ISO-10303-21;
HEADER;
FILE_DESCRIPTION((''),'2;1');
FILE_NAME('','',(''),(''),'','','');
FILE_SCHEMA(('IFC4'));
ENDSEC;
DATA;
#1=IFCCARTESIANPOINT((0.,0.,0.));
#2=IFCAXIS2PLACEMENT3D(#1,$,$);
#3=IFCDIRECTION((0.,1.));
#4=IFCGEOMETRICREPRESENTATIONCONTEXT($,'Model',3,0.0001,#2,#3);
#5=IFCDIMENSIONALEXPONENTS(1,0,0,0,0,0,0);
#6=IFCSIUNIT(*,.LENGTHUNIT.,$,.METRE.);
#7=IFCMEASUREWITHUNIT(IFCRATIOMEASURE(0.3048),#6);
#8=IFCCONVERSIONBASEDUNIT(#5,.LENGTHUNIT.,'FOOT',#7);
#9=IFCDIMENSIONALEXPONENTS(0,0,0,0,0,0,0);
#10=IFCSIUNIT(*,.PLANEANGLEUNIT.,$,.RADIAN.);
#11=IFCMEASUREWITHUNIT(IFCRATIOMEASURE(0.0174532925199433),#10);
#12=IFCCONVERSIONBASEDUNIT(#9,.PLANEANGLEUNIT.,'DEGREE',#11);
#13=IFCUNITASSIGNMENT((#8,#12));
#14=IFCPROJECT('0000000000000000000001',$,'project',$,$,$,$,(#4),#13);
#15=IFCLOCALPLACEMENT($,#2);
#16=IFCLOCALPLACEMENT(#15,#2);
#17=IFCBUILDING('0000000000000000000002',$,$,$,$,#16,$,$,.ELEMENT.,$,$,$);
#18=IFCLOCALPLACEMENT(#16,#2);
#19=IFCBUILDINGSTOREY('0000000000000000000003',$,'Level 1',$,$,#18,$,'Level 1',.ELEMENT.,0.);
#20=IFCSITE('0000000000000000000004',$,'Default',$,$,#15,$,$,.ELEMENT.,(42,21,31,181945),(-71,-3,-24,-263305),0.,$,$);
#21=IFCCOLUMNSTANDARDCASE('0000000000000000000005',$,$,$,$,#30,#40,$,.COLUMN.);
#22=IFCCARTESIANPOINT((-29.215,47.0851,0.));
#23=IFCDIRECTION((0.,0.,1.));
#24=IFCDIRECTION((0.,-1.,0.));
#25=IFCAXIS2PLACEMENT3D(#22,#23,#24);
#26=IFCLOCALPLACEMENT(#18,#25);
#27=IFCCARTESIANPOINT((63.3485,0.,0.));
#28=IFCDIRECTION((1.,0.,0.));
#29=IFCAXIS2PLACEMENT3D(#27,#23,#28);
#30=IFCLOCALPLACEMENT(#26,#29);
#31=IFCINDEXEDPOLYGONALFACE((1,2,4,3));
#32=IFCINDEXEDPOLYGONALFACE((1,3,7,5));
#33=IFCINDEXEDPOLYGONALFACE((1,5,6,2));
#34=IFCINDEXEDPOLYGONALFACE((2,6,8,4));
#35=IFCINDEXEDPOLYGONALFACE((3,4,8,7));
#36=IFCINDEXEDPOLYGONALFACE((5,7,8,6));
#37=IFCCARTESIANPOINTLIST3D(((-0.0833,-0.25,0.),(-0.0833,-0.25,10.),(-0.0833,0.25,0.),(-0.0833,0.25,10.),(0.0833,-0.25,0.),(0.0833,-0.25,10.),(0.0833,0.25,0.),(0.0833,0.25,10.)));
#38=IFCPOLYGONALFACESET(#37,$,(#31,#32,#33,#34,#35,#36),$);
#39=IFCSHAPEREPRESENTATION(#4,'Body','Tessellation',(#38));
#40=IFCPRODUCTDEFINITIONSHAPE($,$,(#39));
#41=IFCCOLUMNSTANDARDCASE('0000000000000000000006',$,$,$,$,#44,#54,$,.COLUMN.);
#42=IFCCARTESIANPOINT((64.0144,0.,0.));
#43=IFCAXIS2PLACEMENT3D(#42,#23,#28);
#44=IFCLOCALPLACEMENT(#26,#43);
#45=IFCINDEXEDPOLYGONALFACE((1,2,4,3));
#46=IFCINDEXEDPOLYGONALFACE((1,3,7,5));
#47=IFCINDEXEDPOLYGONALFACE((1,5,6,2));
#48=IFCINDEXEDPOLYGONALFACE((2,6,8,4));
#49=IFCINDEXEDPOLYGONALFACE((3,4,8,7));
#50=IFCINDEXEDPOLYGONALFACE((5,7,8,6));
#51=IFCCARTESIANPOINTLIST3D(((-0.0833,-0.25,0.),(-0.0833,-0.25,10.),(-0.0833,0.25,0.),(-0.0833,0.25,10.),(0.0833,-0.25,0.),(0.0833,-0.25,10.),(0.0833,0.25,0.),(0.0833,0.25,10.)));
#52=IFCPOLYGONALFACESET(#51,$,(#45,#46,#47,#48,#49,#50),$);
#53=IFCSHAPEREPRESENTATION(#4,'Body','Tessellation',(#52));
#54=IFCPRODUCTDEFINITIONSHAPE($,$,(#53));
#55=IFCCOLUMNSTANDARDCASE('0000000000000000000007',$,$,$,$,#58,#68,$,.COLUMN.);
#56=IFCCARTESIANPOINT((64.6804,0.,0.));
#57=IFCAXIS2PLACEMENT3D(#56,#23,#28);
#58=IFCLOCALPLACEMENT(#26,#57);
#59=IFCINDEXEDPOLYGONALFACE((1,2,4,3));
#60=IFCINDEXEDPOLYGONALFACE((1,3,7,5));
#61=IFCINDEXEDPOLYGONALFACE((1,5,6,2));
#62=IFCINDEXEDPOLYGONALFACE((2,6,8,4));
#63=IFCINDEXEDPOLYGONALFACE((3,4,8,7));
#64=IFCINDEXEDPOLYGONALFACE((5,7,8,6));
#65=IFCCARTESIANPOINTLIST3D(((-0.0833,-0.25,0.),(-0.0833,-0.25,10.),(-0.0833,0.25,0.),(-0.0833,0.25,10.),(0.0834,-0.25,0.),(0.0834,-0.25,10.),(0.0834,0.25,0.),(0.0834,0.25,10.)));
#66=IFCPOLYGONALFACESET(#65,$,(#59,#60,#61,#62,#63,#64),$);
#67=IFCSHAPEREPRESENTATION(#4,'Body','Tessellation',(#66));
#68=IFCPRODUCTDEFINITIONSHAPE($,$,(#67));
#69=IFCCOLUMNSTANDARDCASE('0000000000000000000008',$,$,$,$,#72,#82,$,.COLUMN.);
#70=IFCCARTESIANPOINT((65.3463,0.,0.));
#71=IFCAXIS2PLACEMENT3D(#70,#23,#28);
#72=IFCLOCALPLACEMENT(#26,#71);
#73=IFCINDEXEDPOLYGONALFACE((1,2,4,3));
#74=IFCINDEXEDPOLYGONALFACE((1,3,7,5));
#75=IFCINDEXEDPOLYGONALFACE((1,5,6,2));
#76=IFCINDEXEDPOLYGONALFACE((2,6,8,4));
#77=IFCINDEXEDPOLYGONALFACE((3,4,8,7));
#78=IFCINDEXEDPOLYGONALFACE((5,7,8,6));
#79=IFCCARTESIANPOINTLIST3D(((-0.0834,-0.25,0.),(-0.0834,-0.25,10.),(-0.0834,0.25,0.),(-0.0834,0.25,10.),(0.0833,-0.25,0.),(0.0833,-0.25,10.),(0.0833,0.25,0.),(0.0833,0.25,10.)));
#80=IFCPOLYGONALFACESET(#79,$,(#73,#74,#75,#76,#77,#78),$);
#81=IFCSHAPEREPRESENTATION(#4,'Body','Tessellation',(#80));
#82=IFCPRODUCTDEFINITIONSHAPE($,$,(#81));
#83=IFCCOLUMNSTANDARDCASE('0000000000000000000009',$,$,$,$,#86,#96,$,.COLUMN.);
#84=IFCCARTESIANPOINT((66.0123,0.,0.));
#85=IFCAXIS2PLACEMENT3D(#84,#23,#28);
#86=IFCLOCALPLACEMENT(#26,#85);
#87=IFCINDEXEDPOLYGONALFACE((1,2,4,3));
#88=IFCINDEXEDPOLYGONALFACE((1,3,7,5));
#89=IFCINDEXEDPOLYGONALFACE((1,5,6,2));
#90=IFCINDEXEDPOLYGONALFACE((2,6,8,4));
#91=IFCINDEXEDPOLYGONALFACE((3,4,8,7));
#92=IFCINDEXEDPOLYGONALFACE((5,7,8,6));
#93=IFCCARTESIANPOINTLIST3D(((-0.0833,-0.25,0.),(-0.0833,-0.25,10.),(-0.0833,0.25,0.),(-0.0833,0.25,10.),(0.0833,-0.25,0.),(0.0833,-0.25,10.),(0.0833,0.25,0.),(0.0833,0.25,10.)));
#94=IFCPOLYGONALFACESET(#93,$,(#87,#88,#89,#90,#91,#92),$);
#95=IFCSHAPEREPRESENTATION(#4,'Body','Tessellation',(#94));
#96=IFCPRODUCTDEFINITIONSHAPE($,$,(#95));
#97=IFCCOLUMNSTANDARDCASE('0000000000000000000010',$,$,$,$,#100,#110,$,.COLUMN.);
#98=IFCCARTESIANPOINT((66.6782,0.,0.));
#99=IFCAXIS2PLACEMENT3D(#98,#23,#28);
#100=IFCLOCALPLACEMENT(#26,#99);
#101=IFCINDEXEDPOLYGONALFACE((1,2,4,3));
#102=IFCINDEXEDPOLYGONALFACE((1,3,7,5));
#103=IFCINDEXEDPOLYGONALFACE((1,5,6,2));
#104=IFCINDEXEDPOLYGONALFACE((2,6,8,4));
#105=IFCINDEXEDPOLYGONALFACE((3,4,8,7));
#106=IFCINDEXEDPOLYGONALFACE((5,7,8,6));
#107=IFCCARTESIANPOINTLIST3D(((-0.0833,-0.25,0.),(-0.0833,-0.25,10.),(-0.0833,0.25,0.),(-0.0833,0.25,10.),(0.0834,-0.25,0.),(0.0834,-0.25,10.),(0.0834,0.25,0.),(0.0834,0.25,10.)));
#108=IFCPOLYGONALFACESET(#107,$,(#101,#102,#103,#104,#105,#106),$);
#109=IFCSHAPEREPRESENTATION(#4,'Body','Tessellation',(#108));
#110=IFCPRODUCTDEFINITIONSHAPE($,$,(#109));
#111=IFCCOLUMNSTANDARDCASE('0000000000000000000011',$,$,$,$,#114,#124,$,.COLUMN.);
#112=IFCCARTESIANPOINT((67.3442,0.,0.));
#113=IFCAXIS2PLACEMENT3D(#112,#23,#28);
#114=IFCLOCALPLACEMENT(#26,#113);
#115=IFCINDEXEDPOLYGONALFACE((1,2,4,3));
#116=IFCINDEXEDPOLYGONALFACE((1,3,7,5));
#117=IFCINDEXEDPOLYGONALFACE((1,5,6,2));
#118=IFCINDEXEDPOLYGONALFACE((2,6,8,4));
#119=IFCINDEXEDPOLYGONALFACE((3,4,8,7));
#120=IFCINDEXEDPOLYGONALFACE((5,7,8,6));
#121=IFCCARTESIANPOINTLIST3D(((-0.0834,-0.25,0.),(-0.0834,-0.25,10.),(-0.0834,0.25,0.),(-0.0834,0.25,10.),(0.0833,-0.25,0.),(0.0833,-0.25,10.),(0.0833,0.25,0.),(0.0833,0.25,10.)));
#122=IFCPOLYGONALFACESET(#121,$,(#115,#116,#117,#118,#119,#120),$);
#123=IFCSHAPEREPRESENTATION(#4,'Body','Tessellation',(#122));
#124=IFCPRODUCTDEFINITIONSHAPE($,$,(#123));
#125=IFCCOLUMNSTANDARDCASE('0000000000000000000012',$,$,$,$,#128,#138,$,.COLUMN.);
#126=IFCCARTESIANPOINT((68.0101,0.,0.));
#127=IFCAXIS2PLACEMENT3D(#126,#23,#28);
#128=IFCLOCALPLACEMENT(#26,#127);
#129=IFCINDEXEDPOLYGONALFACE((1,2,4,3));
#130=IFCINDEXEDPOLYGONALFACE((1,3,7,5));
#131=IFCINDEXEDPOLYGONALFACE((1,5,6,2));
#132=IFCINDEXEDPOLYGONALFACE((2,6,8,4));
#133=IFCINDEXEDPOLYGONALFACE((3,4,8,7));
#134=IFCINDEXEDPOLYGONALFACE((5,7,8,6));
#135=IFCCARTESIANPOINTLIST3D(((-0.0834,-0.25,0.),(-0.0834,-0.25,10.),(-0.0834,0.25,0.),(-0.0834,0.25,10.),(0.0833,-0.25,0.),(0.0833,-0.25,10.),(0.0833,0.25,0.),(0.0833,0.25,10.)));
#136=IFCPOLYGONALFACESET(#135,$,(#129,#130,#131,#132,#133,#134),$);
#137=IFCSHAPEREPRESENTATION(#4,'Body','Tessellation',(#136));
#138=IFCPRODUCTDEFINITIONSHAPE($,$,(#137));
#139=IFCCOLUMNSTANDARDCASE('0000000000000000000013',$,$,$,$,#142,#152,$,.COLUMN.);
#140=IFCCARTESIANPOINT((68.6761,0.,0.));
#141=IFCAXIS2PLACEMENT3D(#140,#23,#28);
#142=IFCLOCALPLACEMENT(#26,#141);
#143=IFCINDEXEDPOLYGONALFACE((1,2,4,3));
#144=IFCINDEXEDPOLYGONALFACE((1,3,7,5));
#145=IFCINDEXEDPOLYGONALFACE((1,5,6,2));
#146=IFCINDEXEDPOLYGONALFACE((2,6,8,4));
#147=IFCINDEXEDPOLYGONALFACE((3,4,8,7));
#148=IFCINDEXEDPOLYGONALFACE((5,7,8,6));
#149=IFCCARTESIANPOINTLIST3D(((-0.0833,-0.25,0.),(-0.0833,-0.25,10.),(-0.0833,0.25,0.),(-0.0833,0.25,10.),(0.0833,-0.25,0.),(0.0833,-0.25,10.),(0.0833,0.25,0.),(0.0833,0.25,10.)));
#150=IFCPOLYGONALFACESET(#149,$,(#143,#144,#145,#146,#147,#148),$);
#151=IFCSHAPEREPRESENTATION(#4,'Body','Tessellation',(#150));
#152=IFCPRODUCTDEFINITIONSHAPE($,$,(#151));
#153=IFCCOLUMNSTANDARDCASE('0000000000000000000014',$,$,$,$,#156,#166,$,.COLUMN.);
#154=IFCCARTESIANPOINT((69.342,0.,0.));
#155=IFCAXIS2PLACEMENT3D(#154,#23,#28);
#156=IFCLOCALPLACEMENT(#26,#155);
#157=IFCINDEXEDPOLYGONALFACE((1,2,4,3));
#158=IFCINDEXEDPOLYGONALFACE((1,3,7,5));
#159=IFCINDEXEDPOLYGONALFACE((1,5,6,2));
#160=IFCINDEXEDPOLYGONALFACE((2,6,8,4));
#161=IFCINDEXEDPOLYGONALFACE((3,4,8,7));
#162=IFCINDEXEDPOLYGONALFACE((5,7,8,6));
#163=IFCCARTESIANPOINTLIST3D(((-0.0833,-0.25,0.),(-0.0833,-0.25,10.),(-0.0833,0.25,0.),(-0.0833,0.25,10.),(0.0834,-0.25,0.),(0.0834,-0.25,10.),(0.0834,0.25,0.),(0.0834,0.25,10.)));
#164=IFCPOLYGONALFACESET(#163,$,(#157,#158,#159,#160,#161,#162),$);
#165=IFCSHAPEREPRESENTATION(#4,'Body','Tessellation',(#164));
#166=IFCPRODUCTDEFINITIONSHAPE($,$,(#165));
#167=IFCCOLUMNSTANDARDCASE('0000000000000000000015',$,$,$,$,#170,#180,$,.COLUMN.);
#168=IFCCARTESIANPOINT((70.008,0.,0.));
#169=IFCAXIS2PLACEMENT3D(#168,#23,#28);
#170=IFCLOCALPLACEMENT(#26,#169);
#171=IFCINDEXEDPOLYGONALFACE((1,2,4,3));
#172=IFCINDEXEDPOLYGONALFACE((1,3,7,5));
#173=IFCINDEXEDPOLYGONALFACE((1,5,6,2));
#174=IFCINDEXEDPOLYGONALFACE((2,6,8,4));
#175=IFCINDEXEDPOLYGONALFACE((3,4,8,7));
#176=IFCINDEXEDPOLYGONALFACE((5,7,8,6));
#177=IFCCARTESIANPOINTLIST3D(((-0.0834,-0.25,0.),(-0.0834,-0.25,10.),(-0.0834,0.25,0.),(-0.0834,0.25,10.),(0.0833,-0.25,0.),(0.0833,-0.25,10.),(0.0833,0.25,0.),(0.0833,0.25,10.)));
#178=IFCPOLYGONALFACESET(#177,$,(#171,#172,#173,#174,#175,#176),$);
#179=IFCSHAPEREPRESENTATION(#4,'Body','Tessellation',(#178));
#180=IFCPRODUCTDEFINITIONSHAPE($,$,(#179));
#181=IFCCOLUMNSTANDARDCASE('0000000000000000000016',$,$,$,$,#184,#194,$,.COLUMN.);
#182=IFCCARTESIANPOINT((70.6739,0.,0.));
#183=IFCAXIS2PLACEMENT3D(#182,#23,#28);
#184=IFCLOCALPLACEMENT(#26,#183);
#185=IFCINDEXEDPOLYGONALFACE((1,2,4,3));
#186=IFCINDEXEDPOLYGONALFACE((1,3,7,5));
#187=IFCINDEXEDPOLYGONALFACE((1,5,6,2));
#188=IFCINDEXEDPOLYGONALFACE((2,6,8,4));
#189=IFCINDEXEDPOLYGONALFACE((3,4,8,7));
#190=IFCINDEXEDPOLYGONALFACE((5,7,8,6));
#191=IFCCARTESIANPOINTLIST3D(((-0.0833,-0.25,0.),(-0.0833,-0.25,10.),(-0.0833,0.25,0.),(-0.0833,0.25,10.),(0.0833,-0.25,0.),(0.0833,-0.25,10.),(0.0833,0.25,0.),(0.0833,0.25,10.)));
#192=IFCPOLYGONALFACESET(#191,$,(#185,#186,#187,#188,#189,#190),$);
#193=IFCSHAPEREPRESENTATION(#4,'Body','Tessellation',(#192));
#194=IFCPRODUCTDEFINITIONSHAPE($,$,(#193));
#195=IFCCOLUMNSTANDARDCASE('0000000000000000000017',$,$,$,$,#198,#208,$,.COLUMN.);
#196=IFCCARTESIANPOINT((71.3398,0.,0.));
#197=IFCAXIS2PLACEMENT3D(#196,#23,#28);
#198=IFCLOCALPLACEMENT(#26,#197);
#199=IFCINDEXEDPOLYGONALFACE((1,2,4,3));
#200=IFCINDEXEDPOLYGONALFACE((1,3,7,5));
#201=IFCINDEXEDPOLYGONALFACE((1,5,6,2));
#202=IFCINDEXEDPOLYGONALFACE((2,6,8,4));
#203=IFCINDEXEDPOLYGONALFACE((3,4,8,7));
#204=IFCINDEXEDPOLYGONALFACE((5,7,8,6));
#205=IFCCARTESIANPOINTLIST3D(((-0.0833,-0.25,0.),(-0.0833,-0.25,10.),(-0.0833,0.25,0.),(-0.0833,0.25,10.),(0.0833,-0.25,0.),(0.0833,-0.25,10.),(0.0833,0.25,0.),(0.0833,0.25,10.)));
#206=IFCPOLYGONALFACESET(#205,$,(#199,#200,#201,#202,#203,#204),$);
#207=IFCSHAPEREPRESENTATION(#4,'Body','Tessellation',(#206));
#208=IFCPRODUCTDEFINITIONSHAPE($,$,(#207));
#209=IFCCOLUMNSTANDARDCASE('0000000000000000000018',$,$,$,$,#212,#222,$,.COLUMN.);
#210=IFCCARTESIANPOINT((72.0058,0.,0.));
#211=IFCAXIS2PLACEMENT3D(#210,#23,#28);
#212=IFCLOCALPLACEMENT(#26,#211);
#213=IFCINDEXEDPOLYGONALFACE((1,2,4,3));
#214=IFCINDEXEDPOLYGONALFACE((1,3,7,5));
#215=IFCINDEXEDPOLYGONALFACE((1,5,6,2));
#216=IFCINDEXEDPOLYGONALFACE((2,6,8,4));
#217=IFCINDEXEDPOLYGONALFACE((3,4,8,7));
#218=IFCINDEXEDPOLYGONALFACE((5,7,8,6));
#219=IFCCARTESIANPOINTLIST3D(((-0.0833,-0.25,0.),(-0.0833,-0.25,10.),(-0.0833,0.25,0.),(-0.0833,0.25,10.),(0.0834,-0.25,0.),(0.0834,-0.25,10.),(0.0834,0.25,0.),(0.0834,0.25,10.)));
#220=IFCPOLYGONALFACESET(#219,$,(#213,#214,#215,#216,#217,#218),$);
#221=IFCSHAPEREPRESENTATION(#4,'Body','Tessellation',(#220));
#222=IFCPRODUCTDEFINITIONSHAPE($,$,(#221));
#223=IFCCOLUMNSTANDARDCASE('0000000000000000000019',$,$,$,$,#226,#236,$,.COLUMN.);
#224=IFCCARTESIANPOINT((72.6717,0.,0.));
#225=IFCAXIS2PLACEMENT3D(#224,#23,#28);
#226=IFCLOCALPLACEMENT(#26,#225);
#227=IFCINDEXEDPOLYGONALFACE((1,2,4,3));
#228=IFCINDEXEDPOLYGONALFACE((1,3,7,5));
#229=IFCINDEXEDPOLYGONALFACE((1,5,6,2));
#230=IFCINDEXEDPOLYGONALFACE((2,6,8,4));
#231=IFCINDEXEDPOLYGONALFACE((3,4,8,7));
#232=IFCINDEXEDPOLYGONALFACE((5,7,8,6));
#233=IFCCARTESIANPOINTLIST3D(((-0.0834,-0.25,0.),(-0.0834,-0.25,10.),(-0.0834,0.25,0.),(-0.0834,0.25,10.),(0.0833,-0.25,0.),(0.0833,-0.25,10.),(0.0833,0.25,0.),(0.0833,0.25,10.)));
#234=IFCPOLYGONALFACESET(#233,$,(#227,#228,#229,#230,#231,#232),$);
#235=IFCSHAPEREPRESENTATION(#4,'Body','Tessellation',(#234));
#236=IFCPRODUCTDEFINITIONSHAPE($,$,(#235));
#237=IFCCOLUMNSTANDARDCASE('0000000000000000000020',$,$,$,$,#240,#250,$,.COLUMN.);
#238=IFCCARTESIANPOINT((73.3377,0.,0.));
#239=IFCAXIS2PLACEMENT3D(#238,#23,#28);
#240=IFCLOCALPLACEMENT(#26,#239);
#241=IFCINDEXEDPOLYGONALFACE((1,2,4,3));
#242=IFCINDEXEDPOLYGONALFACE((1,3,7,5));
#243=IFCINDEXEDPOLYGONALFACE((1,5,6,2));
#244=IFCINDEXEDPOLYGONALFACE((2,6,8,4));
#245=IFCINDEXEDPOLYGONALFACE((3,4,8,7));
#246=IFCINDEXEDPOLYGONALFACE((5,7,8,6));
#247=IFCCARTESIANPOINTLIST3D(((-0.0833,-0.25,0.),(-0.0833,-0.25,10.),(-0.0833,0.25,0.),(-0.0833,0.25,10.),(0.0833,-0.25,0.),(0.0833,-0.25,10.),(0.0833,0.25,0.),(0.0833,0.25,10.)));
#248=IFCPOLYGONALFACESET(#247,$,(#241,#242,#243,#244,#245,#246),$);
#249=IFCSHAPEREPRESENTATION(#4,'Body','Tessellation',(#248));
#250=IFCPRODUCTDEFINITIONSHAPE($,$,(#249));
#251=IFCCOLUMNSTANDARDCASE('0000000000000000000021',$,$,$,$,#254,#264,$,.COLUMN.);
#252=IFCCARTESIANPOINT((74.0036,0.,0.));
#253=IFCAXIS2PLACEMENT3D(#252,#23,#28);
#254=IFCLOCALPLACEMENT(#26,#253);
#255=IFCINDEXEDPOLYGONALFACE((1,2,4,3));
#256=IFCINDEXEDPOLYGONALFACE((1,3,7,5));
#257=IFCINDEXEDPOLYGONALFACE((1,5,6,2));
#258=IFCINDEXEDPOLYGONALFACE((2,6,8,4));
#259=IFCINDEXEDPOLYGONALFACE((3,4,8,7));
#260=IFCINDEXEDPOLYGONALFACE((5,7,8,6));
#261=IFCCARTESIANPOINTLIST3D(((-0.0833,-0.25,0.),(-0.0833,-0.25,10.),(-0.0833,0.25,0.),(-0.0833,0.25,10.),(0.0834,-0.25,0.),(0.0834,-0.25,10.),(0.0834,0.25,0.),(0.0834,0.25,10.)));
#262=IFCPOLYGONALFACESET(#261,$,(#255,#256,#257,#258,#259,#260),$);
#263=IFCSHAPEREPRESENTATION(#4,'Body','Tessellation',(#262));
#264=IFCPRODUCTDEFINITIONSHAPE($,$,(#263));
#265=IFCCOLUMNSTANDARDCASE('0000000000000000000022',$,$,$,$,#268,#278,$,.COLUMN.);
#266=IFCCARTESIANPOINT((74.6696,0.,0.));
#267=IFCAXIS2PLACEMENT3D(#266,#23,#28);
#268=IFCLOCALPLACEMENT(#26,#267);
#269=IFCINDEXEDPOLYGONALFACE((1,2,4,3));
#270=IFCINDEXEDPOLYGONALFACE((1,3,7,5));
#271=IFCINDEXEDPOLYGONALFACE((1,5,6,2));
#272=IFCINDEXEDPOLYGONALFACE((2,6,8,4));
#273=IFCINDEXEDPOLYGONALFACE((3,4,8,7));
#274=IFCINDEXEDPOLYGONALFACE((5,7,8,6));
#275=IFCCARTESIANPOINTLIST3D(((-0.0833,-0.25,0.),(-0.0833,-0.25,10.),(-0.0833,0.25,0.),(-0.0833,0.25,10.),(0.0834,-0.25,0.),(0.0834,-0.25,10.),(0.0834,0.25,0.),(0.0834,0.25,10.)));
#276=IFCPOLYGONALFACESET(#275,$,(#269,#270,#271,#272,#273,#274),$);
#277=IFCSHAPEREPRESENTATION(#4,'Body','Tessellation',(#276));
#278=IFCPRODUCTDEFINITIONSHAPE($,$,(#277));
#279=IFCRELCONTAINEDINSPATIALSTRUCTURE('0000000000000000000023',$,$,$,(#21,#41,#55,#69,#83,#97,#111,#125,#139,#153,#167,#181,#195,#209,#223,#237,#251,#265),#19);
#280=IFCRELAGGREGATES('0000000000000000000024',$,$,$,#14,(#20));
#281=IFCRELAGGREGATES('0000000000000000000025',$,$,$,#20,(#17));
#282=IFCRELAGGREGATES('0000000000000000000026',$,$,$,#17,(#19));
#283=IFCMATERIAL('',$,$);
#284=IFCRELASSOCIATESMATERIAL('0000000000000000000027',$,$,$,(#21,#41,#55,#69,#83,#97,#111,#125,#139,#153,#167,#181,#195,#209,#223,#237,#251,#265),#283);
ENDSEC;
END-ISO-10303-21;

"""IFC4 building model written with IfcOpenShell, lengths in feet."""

from ifc_helpers import new_model, entity, si_unit, converted_unit, direction, frame, origin, place, context, project, spatial, rectangle, extrude, material, element, save


model = new_model("IFC4")

# Units and contexts
model_context = context("Model", 3, precision=0.0001, world=origin(), true_north=direction((0.0, 1.0)))
ifc_project = project(units=[converted_unit("LENGTHUNIT", "FOOT", entity("IfcRatioMeasure", 0.3048), si_unit("LENGTHUNIT", "METRE"), dimensions=[1, 0, 0, 0, 0, 0, 0]), converted_unit("PLANEANGLEUNIT", "DEGREE", entity("IfcRatioMeasure", 0.0174532925199433), si_unit("PLANEANGLEUNIT", "RADIAN"), dimensions=[0, 0, 0, 0, 0, 0, 0])], contexts=[model_context])

# Site, building, storey
site_placement = place(None, origin())
site = spatial("IfcSite", under=ifc_project, at=site_placement, Name="Default", CompositionType="ELEMENT", RefLatitude=(42, 21, 31, 181945), RefLongitude=(-71, -3, -24, -263305), RefElevation=0.0)
building_placement = place(site_placement, origin())
building = spatial("IfcBuilding", under=site, at=building_placement, CompositionType="ELEMENT")
storey_placement = place(building_placement, origin())
storey = spatial("IfcBuildingStorey", under=building, at=storey_placement, Name="Level 1", LongName="Level 1", CompositionType="ELEMENT", Elevation=0.0)

# Columns
ifc_material_1 = material(Name="")
placement = place(storey_placement, frame((-29.215, 47.0851, 0.0), z_axis=(0.0, 0.0, 1.0), x_axis=(0.0, -1.0, 0.0)))
for number, where, z_axis, x_axis in (
    (1, (63.3485, 0.0, 0.0), (0.0, 0.0, 1.0), (1.0, 0.0, 0.0)),
    (2, (64.0144, 0.0, 0.0), (0.0, 0.0, 1.0), (1.0, 0.0, 0.0)),
    (3, (64.6804, 0.0, 0.0), (0.0, 0.0, 1.0), (1.0, 0.0, 0.0)),
    (4, (65.3463, 0.0, 0.0), (0.0, 0.0, 1.0), (1.0, 0.0, 0.0)),
    (5, (66.0123, 0.0, 0.0), (0.0, 0.0, 1.0), (1.0, 0.0, 0.0)),
    (6, (66.6782, 0.0, 0.0), (0.0, 0.0, 1.0), (1.0, 0.0, 0.0)),
    (7, (67.3442, 0.0, 0.0), (0.0, 0.0, 1.0), (1.0, 0.0, 0.0)),
    (8, (68.0101, 0.0, 0.0), (0.0, 0.0, 1.0), (1.0, 0.0, 0.0)),
    (9, (68.6761, 0.0, 0.0), (0.0, 0.0, 1.0), (1.0, 0.0, 0.0)),
    (10, (69.342, 0.0, 0.0), (0.0, 0.0, 1.0), (1.0, 0.0, 0.0)),
    (11, (70.008, 0.0, 0.0), (0.0, 0.0, 1.0), (1.0, 0.0, 0.0)),
    (12, (70.6739, 0.0, 0.0), (0.0, 0.0, 1.0), (1.0, 0.0, 0.0)),
    (13, (71.3398, 0.0, 0.0), (0.0, 0.0, 1.0), (1.0, 0.0, 0.0)),
    (14, (72.0058, 0.0, 0.0), (0.0, 0.0, 1.0), (1.0, 0.0, 0.0)),
    (15, (72.6717, 0.0, 0.0), (0.0, 0.0, 1.0), (1.0, 0.0, 0.0)),
    (16, (73.3377, 0.0, 0.0), (0.0, 0.0, 1.0), (1.0, 0.0, 0.0)),
    (17, (74.0036, 0.0, 0.0), (0.0, 0.0, 1.0), (1.0, 0.0, 0.0)),
    (18, (74.6696, 0.0, 0.0), (0.0, 0.0, 1.0), (1.0, 0.0, 0.0)),
):
    element("IfcColumnStandardCase", number, at=place(placement, frame(where, z_axis=z_axis, x_axis=x_axis)), inside=storey, material=ifc_material_1, PredefinedType="COLUMN", context=model_context, shape_type="SweptSolid", body=[
        extrude(rectangle(XDim=0.1667, YDim=0.5), origin(), (0.0, 0.0, 1.0), 10.0),
    ])

save(model, "model.ifc")
